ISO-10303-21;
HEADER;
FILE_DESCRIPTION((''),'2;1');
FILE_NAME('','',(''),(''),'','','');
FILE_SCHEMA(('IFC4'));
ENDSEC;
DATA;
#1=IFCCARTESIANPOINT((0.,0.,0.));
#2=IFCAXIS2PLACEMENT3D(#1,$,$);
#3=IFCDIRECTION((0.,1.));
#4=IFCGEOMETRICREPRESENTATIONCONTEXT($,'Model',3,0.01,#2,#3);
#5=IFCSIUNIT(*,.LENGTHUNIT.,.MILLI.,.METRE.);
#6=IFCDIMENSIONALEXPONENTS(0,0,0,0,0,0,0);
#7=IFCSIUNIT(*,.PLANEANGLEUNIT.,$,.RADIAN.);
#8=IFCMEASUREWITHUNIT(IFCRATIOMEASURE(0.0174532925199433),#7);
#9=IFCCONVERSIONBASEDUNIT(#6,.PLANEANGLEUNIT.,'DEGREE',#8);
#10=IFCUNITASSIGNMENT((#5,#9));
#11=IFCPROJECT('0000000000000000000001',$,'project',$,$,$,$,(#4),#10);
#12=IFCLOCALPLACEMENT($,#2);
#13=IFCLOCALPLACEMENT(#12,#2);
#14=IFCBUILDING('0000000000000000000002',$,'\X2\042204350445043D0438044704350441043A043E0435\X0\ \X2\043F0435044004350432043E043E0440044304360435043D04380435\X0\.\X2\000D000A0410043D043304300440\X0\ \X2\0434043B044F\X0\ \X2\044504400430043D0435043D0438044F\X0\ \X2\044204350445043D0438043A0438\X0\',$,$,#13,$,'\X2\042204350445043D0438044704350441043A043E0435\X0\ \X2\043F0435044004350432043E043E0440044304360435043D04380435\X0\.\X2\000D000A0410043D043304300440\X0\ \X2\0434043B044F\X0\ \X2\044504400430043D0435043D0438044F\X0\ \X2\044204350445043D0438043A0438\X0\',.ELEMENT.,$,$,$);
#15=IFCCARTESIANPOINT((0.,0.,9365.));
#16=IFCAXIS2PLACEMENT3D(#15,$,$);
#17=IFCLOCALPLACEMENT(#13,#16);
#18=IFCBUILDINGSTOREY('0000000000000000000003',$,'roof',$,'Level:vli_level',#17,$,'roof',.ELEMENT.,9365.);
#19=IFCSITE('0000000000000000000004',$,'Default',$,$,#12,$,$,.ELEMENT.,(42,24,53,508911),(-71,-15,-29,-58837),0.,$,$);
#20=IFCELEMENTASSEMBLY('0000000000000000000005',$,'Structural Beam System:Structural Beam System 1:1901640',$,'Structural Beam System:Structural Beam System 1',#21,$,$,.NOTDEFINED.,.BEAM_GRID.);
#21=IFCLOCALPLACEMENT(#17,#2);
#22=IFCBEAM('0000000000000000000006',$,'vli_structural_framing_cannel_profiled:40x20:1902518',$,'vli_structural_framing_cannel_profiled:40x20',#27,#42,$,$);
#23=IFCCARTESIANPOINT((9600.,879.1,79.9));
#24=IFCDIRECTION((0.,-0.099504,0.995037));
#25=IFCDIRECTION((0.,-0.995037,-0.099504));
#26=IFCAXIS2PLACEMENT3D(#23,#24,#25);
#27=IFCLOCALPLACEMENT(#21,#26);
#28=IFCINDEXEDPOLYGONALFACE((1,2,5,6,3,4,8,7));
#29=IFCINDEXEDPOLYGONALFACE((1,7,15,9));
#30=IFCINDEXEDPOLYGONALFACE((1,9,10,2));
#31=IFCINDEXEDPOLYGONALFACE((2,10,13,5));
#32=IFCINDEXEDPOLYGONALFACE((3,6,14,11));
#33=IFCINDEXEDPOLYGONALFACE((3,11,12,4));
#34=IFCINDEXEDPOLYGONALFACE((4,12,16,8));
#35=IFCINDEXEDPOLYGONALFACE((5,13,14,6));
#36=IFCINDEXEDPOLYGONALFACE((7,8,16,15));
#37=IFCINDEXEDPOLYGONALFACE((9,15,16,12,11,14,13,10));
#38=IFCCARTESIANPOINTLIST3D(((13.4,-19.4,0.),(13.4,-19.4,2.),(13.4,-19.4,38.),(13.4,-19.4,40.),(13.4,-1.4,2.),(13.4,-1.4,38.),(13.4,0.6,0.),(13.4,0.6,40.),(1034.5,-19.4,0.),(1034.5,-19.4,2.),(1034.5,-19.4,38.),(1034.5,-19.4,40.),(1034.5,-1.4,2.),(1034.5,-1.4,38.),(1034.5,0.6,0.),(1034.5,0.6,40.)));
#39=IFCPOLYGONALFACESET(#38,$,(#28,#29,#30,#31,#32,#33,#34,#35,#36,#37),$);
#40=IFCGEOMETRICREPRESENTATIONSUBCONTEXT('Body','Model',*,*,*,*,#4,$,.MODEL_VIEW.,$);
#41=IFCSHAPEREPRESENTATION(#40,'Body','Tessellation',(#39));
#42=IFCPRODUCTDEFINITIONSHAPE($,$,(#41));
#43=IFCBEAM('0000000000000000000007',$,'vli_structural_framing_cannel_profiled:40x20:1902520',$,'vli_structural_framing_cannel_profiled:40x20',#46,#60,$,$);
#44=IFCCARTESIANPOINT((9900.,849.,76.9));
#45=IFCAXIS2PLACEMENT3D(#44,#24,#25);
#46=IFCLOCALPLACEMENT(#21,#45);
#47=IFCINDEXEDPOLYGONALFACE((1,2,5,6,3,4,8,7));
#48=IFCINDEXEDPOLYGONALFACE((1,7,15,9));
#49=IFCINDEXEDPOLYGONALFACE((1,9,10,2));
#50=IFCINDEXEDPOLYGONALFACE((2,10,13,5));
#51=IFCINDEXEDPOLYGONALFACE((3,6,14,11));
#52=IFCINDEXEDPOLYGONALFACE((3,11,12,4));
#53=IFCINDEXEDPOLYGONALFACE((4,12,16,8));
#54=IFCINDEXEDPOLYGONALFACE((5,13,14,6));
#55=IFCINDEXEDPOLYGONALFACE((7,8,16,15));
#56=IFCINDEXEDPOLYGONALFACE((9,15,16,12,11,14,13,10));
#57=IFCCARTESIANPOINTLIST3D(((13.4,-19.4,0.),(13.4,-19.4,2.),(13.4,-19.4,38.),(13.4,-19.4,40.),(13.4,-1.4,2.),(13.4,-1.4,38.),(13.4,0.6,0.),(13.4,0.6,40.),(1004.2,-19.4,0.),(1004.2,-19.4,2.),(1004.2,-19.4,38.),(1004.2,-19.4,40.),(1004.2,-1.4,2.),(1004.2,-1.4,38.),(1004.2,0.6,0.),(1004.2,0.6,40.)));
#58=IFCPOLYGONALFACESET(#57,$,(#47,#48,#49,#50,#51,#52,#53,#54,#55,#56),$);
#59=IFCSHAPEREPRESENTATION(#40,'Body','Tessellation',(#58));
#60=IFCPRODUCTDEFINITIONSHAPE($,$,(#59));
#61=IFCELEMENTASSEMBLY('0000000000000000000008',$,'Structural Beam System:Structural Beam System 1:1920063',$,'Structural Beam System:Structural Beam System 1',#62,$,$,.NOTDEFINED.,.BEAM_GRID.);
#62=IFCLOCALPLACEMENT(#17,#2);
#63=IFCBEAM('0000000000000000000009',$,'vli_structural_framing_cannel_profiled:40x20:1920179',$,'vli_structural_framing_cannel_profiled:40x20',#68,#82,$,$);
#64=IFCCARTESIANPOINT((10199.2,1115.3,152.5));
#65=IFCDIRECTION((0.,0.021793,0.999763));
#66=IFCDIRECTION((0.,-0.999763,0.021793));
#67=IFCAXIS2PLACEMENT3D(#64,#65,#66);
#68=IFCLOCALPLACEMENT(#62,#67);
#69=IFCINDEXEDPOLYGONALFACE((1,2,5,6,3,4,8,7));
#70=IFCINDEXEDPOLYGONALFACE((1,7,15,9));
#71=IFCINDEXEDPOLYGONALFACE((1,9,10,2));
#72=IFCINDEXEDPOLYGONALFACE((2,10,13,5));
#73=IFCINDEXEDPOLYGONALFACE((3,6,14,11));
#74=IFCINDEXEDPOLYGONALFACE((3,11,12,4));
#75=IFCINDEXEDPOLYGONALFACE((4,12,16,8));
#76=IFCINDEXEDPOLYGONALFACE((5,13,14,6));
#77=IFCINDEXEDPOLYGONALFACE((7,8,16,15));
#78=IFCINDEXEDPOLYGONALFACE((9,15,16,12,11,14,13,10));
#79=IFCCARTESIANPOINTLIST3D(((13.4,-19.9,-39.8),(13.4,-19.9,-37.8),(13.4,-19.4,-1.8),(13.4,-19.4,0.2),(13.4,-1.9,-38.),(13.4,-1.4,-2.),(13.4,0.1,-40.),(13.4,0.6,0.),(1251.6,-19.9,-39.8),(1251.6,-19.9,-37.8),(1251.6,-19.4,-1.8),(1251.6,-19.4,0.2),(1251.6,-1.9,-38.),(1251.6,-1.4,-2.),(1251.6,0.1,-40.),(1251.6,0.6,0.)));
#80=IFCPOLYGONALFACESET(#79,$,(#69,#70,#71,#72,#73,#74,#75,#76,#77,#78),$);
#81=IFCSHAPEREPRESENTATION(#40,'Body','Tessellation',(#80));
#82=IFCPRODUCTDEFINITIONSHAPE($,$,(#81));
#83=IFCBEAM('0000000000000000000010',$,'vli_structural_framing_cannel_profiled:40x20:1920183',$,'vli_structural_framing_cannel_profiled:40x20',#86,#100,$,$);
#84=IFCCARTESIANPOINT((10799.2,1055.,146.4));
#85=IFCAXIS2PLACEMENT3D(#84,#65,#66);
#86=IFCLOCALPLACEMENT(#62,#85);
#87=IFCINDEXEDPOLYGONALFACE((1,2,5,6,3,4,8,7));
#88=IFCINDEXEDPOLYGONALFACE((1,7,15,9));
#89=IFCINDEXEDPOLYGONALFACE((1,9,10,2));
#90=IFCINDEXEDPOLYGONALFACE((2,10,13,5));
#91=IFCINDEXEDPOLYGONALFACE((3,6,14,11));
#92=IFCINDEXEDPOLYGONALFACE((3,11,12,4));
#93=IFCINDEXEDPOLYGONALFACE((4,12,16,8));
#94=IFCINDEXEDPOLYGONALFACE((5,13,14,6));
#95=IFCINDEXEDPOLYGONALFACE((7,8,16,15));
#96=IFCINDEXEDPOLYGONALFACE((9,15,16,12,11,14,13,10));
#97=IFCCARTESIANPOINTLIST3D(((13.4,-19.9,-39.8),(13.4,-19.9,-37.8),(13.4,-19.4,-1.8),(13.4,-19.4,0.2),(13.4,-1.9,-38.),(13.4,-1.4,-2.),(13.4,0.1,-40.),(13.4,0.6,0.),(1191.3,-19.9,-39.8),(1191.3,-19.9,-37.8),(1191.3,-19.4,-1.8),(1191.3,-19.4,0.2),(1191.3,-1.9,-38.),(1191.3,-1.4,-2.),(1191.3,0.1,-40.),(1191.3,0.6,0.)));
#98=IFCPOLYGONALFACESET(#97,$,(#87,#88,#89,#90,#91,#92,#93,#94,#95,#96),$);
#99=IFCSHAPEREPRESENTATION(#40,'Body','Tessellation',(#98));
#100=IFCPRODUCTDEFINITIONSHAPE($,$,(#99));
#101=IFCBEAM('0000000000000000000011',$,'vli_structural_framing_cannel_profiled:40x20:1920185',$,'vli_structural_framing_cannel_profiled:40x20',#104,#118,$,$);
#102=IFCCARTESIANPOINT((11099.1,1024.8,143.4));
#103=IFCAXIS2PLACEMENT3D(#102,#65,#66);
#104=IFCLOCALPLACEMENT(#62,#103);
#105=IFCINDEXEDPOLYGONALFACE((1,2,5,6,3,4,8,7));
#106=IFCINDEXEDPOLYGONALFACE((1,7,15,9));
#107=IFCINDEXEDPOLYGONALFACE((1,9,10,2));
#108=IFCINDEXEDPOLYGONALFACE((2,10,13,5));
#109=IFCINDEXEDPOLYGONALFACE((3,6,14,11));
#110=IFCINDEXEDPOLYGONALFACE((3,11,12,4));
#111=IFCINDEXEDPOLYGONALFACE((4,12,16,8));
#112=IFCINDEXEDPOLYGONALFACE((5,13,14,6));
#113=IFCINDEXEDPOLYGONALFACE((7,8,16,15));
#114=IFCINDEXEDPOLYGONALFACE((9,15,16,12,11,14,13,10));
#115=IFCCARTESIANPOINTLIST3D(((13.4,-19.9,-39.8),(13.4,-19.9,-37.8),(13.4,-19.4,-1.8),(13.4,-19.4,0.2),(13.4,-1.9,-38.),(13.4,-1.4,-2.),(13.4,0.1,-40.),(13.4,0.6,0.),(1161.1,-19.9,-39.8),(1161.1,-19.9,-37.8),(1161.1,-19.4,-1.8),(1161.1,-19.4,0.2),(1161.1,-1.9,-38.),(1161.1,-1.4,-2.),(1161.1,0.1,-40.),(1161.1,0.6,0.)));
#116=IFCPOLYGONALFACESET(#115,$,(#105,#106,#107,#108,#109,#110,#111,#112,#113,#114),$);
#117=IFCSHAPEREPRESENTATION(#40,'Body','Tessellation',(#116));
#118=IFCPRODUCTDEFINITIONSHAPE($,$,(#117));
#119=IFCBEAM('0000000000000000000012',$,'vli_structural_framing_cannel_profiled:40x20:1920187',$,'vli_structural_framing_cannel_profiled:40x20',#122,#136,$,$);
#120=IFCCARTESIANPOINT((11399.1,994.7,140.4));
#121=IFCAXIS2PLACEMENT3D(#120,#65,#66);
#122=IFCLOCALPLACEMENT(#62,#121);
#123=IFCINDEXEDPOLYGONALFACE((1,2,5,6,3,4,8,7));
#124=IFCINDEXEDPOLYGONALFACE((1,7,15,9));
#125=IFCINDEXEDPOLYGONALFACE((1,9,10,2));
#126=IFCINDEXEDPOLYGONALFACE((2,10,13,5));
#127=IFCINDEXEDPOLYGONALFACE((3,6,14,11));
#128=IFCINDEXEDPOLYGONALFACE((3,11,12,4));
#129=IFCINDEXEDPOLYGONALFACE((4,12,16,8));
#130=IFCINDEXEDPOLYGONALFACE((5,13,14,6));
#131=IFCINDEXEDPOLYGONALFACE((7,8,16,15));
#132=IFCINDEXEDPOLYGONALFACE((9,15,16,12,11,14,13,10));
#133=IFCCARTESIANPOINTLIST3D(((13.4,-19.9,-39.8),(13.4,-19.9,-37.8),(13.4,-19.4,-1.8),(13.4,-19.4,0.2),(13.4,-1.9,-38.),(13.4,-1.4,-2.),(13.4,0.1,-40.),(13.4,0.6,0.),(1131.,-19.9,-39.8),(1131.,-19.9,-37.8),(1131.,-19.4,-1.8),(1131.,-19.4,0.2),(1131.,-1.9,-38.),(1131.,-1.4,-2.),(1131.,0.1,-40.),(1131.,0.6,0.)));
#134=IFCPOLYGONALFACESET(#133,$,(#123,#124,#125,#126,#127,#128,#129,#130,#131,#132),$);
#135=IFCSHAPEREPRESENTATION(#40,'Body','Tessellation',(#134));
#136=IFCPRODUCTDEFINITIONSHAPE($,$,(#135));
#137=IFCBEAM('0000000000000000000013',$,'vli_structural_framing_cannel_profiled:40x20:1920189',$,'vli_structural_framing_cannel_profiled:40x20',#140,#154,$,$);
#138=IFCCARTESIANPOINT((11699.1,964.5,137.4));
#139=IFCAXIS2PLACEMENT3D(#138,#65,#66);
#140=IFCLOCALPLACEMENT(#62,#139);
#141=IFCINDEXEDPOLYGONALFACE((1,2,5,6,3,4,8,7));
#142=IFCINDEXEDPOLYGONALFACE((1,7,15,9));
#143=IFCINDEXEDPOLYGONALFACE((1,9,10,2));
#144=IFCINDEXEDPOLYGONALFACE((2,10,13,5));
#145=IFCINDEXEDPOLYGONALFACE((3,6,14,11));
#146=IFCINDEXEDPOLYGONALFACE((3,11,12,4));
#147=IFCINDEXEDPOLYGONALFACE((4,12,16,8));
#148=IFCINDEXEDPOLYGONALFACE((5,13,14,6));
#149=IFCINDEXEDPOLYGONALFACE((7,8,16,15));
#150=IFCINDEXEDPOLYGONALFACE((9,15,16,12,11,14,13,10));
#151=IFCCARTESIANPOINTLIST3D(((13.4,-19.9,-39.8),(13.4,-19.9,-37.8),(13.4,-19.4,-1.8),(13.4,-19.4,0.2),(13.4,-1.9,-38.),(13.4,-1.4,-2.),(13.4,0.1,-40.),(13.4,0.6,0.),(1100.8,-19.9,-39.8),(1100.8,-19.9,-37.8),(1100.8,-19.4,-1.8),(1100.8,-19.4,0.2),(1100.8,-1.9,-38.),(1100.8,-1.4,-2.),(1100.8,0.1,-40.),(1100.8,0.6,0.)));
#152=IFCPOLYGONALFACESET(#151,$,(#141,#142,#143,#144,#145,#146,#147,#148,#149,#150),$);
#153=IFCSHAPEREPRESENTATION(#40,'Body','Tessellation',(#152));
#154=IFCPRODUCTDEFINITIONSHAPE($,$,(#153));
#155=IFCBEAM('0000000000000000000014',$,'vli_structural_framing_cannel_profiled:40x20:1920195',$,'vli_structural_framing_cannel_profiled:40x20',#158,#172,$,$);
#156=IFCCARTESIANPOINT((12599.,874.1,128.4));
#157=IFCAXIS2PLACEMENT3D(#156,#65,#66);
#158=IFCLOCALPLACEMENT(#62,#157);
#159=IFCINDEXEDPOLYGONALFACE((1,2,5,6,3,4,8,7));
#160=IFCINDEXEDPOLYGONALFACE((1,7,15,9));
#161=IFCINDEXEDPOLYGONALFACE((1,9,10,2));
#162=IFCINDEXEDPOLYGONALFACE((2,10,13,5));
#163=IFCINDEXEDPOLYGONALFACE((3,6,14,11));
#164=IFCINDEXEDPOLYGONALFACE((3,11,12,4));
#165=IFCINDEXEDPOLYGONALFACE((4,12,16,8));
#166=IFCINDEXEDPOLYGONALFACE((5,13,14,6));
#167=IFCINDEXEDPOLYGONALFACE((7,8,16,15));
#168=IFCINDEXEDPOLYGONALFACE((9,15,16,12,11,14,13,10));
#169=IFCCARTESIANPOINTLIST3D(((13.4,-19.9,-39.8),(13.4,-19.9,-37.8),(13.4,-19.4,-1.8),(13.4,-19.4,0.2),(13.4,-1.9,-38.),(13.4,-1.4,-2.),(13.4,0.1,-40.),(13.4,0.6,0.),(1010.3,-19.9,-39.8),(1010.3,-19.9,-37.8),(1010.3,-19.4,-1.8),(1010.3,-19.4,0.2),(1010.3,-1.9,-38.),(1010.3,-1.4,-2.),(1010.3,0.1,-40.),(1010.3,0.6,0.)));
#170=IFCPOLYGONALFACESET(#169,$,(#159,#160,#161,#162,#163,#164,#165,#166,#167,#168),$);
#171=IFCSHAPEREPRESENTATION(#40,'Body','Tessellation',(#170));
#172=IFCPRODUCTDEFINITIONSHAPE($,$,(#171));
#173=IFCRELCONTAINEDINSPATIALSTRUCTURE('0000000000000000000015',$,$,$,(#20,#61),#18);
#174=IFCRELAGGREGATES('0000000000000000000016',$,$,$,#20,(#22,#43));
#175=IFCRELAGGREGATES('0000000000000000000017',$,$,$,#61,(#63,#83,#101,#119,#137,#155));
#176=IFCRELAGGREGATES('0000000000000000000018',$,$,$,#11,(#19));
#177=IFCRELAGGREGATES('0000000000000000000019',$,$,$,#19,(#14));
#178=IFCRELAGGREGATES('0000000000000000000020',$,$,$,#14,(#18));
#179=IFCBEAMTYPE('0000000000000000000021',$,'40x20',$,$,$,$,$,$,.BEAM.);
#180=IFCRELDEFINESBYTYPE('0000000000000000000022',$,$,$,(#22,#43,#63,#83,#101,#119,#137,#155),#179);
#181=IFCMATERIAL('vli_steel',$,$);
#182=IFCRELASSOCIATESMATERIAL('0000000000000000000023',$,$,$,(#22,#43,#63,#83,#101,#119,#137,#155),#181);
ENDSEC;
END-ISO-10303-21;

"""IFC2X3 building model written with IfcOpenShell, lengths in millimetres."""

from ifc_helpers import new_model, entity, si_unit, converted_unit, direction, frame, origin, place, context, subcontext, project, spatial, polyline, outline, extrude, material, type_object, element, aggregate, save


model = new_model("IFC2X3")

# Units and contexts
model_context = context("Model", 3, precision=0.01, world=origin(), true_north=direction((0.0, 1.0)))
body_context = subcontext(model_context, "Body", "Model", "MODEL_VIEW")
ifc_project = project(units=[si_unit("LENGTHUNIT", "METRE", prefix="MILLI"), converted_unit("PLANEANGLEUNIT", "DEGREE", entity("IfcRatioMeasure", 0.0174532925199433), si_unit("PLANEANGLEUNIT", "RADIAN"), dimensions=[0, 0, 0, 0, 0, 0, 0])], contexts=[model_context])

# Site, building, storey
site_placement = place(None, origin())
site = spatial("IfcSite", under=ifc_project, at=site_placement, Name="Default", CompositionType="ELEMENT", RefLatitude=(42, 24, 53, 508911), RefLongitude=(-71, -15, -29, -58837), RefElevation=0.0)
building_placement = place(site_placement, origin())
building = spatial("IfcBuilding", under=site, at=building_placement, Name="Техническое перевооружение.\r\nАнгар для хранения техники", LongName="Техническое перевооружение.\r\nАнгар для хранения техники", CompositionType="ELEMENT")
storey_placement = place(building_placement, frame((0.0, 0.0, 9365.0)))
storey = spatial("IfcBuildingStorey", under=building, at=storey_placement, Name="roof", ObjectType="Level:vli_level", LongName="roof", CompositionType="ELEMENT", Elevation=9365.0)

# Element assemblies, beams
assembly_1_placement = place(storey_placement, origin())
assembly_1 = element("IfcElementAssembly", 1, at=assembly_1_placement, inside=storey, Name="Structural Beam System:Structural Beam System 1:1901640", ObjectType="Structural Beam System:Structural Beam System 1", AssemblyPlace="NOTDEFINED", PredefinedType="BEAM_GRID")
ifc_material = material(Name="vli_steel")
beam_type = type_object("IfcBeamType", Name="40x20", PredefinedType="BEAM")
beam_1_placement = place(assembly_1_placement, frame((9600.0, 879.1, 79.9), z_axis=(0.0, -0.099504, 0.995037), x_axis=(0.0, -0.995037, -0.099504)))
beam_1 = element("IfcBeam", 2, at=beam_1_placement, type_object=beam_type, material=ifc_material, Name="vli_structural_framing_cannel_profiled:40x20:1902518", ObjectType="vli_structural_framing_cannel_profiled:40x20", context=body_context, shape_type="SweptSolid", body=[
    extrude(outline(polyline([(-20.0, -9.5), (-18.0, -9.5), (-18.0, 8.5), (18.0, 8.5), (18.0, -9.5), (20.0, -9.5), (20.0, 10.5), (-20.0, 10.5), (-20.0, -9.5)])), frame((13.4, -9.9, 20.0), z_axis=(1.0, 0.0, 0.0), x_axis=(0.0, 0.0, -1.0)), (0.0, 0.0, 1.0), 1021.2),
])
beam_2_placement = place(assembly_1_placement, frame((9900.0, 849.0, 76.9), z_axis=(0.0, -0.099504, 0.995037), x_axis=(0.0, -0.995037, -0.099504)))
beam_2 = element("IfcBeam", 3, at=beam_2_placement, type_object=beam_type, material=ifc_material, Name="vli_structural_framing_cannel_profiled:40x20:1902520", ObjectType="vli_structural_framing_cannel_profiled:40x20", context=body_context, shape_type="SweptSolid", body=[
    extrude(outline(polyline([(-20.0, -9.5), (-18.0, -9.5), (-18.0, 8.5), (18.0, 8.5), (18.0, -9.5), (20.0, -9.5), (20.0, 10.5), (-20.0, 10.5), (-20.0, -9.5)])), frame((13.4, -9.9, 20.0), z_axis=(1.0, 0.0, 0.0), x_axis=(0.0, 0.0, -1.0)), (0.0, 0.0, 1.0), 990.9),
])
aggregate(assembly_1, [beam_1, beam_2])
assembly_2_placement = place(storey_placement, origin())
assembly_2 = element("IfcElementAssembly", 4, at=assembly_2_placement, inside=storey, Name="Structural Beam System:Structural Beam System 1:1920063", ObjectType="Structural Beam System:Structural Beam System 1", AssemblyPlace="NOTDEFINED", PredefinedType="BEAM_GRID")
beam_3_placement = place(assembly_2_placement, frame((10199.2, 1115.3, 152.5), z_axis=(0.0, 0.021793, 0.999763), x_axis=(0.0, -0.999763, 0.021793)))
beam_3 = element("IfcBeam", 5, at=beam_3_placement, type_object=beam_type, material=ifc_material, Name="vli_structural_framing_cannel_profiled:40x20:1920179", ObjectType="vli_structural_framing_cannel_profiled:40x20", context=body_context, shape_type="SweptSolid", body=[
    extrude(outline(polyline([(-10.5, -20.0), (9.5, -20.0), (9.5, -18.0), (-8.5, -18.0), (-8.5, 18.0), (9.5, 18.0), (9.5, 20.0), (-10.5, 20.0), (-10.5, -20.0)])), frame((13.4, -10.1, -19.9), z_axis=(1.0, 0.0, 0.0), x_axis=(0.0, -0.999925, 0.012237)), (0.0, 0.0, 1.0), 1238.2),
])
beam_4_placement = place(assembly_2_placement, frame((10799.2, 1055.0, 146.4), z_axis=(0.0, 0.021793, 0.999763), x_axis=(0.0, -0.999763, 0.021793)))
beam_4 = element("IfcBeam", 6, at=beam_4_placement, type_object=beam_type, material=ifc_material, Name="vli_structural_framing_cannel_profiled:40x20:1920183", ObjectType="vli_structural_framing_cannel_profiled:40x20", context=body_context, shape_type="SweptSolid", body=[
    extrude(outline(polyline([(-10.5, -20.0), (9.5, -20.0), (9.5, -18.0), (-8.5, -18.0), (-8.5, 18.0), (9.5, 18.0), (9.5, 20.0), (-10.5, 20.0), (-10.5, -20.0)])), frame((13.4, -10.1, -19.9), z_axis=(1.0, 0.0, 0.0), x_axis=(0.0, -0.999925, 0.012237)), (0.0, 0.0, 1.0), 1177.9),
])
beam_5_placement = place(assembly_2_placement, frame((11099.1, 1024.8, 143.4), z_axis=(0.0, 0.021793, 0.999763), x_axis=(0.0, -0.999763, 0.021793)))
beam_5 = element("IfcBeam", 7, at=beam_5_placement, type_object=beam_type, material=ifc_material, Name="vli_structural_framing_cannel_profiled:40x20:1920185", ObjectType="vli_structural_framing_cannel_profiled:40x20", context=body_context, shape_type="SweptSolid", body=[
    extrude(outline(polyline([(-10.5, -20.0), (9.5, -20.0), (9.5, -18.0), (-8.5, -18.0), (-8.5, 18.0), (9.5, 18.0), (9.5, 20.0), (-10.5, 20.0), (-10.5, -20.0)])), frame((13.4, -10.1, -19.9), z_axis=(1.0, 0.0, 0.0), x_axis=(0.0, -0.999925, 0.012237)), (0.0, 0.0, 1.0), 1147.8),
])
beam_6_placement = place(assembly_2_placement, frame((11399.1, 994.7, 140.4), z_axis=(0.0, 0.021793, 0.999763), x_axis=(0.0, -0.999763, 0.021793)))
beam_6 = element("IfcBeam", 8, at=beam_6_placement, type_object=beam_type, material=ifc_material, Name="vli_structural_framing_cannel_profiled:40x20:1920187", ObjectType="vli_structural_framing_cannel_profiled:40x20", context=body_context, shape_type="SweptSolid", body=[
    extrude(outline(polyline([(-10.5, -20.0), (9.5, -20.0), (9.5, -18.0), (-8.5, -18.0), (-8.5, 18.0), (9.5, 18.0), (9.5, 20.0), (-10.5, 20.0), (-10.5, -20.0)])), frame((13.4, -10.1, -19.9), z_axis=(1.0, 0.0, 0.0), x_axis=(0.0, -0.999925, 0.012237)), (0.0, 0.0, 1.0), 1117.6),
])
beam_7_placement = place(assembly_2_placement, frame((11699.1, 964.5, 137.4), z_axis=(0.0, 0.021793, 0.999763), x_axis=(0.0, -0.999763, 0.021793)))
beam_7 = element("IfcBeam", 9, at=beam_7_placement, type_object=beam_type, material=ifc_material, Name="vli_structural_framing_cannel_profiled:40x20:1920189", ObjectType="vli_structural_framing_cannel_profiled:40x20", context=body_context, shape_type="SweptSolid", body=[
    extrude(outline(polyline([(-10.5, -20.0), (9.5, -20.0), (9.5, -18.0), (-8.5, -18.0), (-8.5, 18.0), (9.5, 18.0), (9.5, 20.0), (-10.5, 20.0), (-10.5, -20.0)])), frame((13.4, -10.1, -19.9), z_axis=(1.0, 0.0, 0.0), x_axis=(0.0, -0.999925, 0.012237)), (0.0, 0.0, 1.0), 1087.4),
])
beam_8_placement = place(assembly_2_placement, frame((12599.0, 874.1, 128.4), z_axis=(0.0, 0.021793, 0.999763), x_axis=(0.0, -0.999763, 0.021793)))
beam_8 = element("IfcBeam", 10, at=beam_8_placement, type_object=beam_type, material=ifc_material, Name="vli_structural_framing_cannel_profiled:40x20:1920195", ObjectType="vli_structural_framing_cannel_profiled:40x20", context=body_context, shape_type="SweptSolid", body=[
    extrude(outline(polyline([(-10.5, -20.0), (9.5, -20.0), (9.5, -18.0), (-8.5, -18.0), (-8.5, 18.0), (9.5, 18.0), (9.5, 20.0), (-10.5, 20.0), (-10.5, -20.0)])), frame((13.4, -10.1, -19.9), z_axis=(1.0, 0.0, 0.0), x_axis=(0.0, -0.999925, 0.012237)), (0.0, 0.0, 1.0), 997.0),
])
aggregate(assembly_2, [beam_3, beam_4, beam_5, beam_6, beam_7, beam_8])

save(model, "model.ifc")
